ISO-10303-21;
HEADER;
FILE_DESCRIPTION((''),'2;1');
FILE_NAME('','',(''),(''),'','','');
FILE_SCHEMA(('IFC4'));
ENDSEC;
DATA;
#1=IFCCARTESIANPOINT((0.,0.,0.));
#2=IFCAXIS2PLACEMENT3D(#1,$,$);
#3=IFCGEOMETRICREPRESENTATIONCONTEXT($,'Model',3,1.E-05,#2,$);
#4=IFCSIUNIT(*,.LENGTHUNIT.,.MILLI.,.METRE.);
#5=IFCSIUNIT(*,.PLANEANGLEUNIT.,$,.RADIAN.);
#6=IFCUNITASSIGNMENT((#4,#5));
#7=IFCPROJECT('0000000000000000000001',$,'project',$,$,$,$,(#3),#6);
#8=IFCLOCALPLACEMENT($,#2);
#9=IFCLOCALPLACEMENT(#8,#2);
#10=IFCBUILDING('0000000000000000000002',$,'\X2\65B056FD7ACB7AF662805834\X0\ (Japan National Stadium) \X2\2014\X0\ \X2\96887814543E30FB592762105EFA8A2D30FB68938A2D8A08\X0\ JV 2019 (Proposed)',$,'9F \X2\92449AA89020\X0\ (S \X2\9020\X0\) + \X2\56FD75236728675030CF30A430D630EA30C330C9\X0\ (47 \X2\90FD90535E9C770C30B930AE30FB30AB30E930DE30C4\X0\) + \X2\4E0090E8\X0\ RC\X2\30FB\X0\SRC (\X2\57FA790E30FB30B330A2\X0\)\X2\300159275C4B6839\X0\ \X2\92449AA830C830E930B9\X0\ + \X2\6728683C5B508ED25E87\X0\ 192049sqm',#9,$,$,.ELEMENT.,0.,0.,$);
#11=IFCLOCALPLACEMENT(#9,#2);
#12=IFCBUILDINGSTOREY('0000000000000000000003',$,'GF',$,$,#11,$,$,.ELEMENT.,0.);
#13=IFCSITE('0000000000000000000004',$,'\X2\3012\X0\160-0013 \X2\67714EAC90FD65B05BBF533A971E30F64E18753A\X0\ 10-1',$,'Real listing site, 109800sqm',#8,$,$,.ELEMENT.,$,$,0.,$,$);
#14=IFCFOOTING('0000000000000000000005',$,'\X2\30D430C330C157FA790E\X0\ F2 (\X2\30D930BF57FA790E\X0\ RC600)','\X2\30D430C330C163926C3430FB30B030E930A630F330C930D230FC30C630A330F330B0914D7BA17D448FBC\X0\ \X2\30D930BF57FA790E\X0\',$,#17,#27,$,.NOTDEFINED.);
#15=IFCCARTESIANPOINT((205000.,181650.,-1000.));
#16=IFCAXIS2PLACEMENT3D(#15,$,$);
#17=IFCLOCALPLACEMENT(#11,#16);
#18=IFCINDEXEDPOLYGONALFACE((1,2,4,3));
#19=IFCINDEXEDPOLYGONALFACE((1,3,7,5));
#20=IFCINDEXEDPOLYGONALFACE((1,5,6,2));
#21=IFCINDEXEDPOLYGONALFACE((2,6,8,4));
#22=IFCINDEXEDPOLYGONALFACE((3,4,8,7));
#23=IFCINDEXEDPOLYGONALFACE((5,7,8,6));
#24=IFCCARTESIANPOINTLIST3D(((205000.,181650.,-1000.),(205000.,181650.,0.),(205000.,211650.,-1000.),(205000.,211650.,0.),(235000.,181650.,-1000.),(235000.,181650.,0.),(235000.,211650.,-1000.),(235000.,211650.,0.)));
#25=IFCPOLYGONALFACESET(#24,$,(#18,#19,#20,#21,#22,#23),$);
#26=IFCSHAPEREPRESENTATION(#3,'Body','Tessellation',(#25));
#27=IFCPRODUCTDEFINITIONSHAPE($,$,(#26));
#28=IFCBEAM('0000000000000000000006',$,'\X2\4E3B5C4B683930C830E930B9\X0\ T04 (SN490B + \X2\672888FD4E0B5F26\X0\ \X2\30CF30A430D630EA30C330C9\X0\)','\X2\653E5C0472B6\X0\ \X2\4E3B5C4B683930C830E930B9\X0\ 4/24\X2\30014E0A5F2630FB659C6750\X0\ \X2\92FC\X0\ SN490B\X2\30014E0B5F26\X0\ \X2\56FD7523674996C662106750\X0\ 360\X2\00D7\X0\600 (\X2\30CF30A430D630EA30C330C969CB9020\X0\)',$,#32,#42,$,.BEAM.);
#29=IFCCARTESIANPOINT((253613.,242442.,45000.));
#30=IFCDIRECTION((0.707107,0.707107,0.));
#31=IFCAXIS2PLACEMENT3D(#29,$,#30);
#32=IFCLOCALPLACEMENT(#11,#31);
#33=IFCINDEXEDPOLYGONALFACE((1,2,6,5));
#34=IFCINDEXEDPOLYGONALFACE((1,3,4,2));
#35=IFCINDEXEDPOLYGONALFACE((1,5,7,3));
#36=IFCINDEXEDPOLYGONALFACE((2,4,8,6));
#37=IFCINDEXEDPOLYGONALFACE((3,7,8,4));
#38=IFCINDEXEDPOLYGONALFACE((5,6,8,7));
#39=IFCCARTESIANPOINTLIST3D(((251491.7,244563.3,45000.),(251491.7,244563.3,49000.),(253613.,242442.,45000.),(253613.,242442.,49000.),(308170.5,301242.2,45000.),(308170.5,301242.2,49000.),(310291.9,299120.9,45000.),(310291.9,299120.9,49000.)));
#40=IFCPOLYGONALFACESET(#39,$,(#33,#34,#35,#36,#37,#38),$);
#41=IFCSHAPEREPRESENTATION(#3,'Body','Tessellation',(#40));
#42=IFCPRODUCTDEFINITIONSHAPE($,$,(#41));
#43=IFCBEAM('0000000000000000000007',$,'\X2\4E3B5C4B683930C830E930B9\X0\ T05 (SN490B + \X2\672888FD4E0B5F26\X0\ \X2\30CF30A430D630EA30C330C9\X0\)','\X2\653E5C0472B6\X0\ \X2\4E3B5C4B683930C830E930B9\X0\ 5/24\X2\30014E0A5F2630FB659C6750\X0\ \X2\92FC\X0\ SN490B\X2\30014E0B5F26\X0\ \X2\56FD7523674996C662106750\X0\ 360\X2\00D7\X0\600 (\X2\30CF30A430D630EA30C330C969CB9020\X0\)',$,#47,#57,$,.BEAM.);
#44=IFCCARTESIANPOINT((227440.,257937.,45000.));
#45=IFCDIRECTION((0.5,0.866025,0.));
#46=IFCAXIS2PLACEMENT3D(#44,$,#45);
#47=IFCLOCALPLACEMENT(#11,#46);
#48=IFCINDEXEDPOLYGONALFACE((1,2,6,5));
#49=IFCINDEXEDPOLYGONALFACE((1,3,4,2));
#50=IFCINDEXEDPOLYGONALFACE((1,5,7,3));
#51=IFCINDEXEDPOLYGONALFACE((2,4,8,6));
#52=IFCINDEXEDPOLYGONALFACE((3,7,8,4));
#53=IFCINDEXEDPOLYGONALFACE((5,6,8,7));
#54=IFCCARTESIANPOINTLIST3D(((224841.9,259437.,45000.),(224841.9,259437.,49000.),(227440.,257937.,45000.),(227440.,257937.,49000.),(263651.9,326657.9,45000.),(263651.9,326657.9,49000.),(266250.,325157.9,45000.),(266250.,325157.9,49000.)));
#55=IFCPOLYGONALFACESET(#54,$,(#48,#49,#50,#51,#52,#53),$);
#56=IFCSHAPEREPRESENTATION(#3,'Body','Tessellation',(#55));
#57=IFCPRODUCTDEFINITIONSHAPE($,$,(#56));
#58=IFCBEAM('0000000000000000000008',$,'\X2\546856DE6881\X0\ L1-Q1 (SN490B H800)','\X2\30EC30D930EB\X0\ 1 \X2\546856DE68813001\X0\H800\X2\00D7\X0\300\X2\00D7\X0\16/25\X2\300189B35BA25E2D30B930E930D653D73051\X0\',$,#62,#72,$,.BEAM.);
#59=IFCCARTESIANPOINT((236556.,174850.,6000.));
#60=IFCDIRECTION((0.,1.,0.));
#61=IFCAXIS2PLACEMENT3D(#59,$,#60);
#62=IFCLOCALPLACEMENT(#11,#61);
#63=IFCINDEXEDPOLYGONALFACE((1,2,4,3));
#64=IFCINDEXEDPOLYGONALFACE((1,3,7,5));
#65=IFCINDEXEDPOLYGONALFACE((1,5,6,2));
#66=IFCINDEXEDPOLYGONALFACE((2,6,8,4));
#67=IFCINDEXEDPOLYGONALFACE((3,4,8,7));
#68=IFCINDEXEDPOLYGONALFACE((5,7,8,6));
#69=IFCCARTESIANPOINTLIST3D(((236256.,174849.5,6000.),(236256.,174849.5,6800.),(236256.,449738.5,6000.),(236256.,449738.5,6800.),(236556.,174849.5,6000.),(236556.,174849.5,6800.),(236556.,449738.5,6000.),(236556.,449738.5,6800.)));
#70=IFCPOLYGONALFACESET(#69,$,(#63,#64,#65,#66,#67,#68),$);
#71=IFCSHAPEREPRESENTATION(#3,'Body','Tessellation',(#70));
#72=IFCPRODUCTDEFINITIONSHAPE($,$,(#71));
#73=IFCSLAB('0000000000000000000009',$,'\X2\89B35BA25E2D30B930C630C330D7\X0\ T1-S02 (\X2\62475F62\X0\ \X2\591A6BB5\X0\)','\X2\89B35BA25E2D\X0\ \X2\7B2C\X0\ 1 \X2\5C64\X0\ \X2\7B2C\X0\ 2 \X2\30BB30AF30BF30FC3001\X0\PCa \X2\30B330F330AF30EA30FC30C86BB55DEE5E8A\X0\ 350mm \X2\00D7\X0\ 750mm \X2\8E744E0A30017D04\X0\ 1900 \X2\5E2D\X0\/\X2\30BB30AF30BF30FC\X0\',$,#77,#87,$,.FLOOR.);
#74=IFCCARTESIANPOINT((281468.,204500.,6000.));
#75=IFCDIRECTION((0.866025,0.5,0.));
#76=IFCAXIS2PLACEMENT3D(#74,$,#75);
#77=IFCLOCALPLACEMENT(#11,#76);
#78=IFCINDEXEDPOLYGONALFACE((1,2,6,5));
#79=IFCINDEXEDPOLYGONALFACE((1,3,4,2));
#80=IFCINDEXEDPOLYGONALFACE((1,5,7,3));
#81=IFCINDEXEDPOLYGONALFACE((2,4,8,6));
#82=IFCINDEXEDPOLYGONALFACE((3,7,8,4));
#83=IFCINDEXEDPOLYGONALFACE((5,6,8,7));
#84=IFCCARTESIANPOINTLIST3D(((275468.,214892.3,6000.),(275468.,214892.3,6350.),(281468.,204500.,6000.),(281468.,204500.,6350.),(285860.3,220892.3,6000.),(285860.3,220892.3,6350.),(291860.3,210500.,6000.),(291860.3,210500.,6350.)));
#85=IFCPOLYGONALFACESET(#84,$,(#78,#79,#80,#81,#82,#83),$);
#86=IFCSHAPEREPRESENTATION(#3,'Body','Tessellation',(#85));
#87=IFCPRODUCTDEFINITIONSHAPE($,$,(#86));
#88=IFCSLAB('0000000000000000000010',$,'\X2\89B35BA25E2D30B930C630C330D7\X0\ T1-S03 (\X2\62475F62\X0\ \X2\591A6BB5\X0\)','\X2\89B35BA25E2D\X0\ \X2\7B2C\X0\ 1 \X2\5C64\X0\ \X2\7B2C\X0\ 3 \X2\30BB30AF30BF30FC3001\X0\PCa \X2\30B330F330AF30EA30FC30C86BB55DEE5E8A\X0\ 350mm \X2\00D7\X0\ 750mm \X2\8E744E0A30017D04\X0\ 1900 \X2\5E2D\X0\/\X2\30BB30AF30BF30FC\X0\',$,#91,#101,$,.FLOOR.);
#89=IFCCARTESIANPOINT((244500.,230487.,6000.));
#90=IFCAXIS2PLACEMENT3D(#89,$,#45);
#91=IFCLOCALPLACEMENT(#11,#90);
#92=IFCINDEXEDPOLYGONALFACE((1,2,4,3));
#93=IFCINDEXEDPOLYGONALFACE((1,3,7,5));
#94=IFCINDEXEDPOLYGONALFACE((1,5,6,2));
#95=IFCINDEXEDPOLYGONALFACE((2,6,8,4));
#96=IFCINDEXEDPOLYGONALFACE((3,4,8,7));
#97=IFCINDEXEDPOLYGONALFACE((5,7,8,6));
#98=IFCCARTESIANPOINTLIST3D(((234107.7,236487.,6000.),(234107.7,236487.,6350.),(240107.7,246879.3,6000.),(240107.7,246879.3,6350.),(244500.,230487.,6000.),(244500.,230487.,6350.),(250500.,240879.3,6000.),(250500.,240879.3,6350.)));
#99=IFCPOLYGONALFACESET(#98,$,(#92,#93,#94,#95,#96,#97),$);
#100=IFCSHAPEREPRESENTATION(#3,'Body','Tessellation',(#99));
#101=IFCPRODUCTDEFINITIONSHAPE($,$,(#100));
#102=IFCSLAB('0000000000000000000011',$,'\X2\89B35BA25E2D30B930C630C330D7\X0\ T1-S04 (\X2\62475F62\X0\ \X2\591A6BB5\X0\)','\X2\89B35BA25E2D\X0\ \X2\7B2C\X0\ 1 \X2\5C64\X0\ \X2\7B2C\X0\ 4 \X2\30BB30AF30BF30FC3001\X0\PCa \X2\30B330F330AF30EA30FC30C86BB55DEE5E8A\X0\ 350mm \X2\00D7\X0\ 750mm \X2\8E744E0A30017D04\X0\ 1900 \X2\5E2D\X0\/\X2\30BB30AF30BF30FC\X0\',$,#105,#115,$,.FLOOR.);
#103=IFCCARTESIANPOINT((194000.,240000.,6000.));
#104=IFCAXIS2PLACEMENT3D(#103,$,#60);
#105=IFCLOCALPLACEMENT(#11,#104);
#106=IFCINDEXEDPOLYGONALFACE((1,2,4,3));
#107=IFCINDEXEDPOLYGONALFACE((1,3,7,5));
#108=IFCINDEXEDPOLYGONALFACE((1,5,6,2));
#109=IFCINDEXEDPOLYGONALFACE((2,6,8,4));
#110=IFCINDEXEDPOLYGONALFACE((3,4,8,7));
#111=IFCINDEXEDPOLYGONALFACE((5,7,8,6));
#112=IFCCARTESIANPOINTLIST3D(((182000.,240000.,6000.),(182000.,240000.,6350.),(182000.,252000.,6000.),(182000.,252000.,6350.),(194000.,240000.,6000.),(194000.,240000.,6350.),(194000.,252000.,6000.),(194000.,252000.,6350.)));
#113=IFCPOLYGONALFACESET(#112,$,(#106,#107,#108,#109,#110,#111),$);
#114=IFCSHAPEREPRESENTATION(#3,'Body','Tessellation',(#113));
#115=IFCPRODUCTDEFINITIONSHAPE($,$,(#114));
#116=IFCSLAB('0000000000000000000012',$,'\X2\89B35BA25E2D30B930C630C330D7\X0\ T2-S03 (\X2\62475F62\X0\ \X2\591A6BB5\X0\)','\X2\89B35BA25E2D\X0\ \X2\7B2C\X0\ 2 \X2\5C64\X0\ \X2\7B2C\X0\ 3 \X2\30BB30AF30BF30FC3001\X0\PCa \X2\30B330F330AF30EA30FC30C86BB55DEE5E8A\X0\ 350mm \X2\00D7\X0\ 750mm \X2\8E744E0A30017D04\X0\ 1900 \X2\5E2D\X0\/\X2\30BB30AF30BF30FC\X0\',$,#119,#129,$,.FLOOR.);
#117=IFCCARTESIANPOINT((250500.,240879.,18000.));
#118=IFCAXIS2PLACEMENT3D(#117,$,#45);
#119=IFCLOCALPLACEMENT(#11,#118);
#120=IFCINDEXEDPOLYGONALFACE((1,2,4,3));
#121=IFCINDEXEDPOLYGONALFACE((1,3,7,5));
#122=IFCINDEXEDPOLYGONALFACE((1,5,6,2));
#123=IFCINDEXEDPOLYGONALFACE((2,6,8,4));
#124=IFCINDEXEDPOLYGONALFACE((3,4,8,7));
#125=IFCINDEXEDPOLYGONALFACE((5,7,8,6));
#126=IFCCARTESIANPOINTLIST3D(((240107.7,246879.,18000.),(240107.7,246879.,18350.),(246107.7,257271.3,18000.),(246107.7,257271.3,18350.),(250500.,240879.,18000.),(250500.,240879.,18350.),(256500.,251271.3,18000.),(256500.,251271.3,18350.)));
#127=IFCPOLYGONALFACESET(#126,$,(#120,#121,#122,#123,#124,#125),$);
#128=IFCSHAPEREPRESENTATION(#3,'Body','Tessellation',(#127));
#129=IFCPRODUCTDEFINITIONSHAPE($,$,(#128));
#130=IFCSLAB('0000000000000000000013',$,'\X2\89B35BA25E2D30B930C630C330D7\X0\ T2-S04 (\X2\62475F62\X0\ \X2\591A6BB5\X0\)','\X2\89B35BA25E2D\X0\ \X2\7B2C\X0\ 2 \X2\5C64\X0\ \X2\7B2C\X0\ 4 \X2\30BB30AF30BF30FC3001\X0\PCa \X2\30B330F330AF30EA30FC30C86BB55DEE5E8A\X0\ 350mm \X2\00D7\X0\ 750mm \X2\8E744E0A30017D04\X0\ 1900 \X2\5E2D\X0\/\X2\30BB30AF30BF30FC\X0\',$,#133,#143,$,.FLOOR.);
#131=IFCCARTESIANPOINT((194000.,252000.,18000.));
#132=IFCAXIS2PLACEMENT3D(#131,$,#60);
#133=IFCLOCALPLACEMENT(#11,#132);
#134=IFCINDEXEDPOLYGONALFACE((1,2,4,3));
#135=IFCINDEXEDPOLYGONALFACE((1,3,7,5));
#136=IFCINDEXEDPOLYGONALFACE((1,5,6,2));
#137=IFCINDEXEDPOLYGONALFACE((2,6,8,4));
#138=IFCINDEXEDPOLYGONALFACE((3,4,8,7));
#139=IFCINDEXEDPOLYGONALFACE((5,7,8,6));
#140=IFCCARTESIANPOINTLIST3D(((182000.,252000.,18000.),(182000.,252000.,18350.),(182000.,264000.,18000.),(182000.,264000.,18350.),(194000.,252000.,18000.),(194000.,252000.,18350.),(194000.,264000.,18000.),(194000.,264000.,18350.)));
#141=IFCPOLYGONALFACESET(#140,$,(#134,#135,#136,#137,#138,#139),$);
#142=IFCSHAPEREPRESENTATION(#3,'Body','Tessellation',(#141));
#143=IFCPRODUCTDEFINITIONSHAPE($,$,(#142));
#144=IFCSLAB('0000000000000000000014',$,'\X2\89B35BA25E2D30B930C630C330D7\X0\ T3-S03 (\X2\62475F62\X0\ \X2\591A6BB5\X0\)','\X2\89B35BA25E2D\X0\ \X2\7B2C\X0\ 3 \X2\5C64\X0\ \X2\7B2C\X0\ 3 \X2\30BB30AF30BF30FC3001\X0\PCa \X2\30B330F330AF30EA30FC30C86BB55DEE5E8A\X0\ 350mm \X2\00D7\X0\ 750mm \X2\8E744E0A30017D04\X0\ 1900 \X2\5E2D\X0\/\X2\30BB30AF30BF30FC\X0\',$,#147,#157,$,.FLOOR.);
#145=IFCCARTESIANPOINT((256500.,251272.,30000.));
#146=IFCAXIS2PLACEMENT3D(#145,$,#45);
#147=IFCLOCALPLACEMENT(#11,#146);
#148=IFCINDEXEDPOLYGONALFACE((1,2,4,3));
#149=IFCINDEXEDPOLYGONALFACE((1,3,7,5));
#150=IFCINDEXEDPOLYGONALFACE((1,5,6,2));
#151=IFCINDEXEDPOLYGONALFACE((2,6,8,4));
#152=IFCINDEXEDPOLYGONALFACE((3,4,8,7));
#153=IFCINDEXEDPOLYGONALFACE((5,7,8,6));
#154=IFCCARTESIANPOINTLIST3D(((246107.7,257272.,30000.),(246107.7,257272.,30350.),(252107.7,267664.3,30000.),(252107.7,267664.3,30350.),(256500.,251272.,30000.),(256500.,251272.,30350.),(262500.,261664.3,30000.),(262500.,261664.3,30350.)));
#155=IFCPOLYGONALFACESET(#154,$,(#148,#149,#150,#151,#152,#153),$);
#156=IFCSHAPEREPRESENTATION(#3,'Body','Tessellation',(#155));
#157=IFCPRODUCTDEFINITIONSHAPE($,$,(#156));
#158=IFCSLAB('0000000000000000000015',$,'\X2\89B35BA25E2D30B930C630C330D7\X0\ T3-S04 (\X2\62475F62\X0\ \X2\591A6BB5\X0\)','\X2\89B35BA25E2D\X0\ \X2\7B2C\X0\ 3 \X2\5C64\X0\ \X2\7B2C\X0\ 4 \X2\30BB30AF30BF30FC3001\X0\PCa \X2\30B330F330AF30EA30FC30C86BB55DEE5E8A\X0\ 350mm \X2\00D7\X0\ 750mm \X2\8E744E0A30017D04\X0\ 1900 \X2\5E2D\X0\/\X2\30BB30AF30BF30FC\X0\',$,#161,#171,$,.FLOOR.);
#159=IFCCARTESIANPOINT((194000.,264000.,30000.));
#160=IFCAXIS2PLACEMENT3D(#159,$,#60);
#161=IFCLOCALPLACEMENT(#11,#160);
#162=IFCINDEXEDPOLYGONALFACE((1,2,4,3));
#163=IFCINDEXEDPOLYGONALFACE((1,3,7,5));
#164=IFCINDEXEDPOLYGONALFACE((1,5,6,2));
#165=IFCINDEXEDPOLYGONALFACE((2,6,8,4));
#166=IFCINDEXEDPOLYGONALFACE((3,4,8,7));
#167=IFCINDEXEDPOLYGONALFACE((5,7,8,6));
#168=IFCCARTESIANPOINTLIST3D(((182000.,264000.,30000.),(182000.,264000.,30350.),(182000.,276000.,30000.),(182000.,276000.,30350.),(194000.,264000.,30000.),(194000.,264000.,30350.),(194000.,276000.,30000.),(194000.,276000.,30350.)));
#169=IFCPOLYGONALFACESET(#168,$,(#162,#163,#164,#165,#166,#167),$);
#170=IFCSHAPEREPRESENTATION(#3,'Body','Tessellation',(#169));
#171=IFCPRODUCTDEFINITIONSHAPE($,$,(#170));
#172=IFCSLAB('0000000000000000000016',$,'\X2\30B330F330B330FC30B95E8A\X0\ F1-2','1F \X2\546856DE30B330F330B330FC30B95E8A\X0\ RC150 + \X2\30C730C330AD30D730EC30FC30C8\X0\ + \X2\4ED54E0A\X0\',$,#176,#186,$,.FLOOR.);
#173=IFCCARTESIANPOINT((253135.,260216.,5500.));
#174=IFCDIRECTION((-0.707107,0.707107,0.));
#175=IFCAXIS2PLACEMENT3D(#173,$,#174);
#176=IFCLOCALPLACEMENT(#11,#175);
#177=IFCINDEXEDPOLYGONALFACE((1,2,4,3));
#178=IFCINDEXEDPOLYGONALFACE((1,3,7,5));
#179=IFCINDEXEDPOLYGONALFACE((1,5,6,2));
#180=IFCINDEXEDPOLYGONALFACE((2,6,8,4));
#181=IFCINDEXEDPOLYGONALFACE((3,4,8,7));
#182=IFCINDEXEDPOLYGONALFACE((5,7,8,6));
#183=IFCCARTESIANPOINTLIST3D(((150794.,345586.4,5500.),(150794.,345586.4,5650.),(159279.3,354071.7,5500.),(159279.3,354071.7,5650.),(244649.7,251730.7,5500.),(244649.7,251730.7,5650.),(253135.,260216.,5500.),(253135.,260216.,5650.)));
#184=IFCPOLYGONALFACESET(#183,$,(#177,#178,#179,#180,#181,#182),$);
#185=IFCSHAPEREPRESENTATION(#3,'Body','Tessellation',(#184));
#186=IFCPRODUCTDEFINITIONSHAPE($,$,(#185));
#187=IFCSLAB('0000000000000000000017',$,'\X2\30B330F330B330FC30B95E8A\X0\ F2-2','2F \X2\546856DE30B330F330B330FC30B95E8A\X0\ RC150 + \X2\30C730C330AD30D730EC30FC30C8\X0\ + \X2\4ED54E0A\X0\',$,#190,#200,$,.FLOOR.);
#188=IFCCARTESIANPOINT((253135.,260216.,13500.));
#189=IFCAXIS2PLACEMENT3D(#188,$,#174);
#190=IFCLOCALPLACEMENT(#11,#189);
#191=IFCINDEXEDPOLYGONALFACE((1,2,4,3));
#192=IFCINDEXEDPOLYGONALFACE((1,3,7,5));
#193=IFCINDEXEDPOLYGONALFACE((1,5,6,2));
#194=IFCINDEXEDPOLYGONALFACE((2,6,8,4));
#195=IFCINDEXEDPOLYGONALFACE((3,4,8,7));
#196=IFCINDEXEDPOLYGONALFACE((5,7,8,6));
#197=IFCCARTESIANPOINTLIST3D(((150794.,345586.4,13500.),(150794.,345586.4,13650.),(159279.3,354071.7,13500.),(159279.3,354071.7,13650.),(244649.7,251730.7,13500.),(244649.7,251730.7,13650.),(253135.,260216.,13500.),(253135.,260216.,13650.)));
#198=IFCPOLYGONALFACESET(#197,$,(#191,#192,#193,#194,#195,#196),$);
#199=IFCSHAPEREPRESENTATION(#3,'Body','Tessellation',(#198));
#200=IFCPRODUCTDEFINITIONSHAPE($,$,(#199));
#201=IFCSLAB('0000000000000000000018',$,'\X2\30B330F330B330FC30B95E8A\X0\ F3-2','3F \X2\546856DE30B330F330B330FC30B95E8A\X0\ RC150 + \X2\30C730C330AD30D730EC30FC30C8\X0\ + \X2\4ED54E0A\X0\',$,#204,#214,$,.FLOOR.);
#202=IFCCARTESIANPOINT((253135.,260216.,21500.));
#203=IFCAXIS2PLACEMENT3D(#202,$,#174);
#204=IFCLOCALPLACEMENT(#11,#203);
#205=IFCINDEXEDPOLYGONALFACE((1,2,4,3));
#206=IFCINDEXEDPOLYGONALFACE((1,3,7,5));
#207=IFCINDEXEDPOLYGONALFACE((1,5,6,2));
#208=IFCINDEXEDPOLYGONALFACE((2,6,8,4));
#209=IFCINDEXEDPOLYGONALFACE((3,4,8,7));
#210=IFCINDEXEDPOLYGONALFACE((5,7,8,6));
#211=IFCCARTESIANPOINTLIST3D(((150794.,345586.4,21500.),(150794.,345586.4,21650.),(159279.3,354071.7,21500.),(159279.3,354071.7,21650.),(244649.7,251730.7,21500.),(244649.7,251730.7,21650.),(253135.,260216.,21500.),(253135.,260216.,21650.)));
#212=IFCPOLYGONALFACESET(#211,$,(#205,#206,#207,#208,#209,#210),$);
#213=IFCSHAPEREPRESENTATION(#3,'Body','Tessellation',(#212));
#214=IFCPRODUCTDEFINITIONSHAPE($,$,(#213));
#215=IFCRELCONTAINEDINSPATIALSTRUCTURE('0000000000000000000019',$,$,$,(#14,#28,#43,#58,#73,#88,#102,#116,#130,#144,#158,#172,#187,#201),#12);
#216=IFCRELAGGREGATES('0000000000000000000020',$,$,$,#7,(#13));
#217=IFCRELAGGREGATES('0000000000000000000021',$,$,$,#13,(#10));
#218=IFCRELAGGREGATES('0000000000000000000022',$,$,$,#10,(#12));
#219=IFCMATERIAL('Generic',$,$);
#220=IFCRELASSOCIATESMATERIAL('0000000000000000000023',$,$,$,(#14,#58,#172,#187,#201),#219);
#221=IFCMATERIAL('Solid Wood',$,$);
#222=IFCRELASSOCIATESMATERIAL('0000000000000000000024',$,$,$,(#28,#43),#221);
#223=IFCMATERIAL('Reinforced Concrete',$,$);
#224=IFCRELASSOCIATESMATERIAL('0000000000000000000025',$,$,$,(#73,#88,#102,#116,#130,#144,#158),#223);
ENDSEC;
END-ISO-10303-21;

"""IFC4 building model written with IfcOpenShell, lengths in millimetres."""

from ifc_helpers import new_model, si_unit, frame, frame_2d, origin, place, context, project, spatial, rectangle, extrude, material, element, save


model = new_model("IFC4")

# Units and contexts
model_context = context("Model", 3, precision=1e-05, world=origin())
ifc_project = project(units=[si_unit("LENGTHUNIT", "METRE", prefix="MILLI"), si_unit("PLANEANGLEUNIT", "RADIAN")], contexts=[model_context])

# Site, building, storey
site_placement = place(None, origin())
site = spatial("IfcSite", under=ifc_project, at=site_placement, Name="〒160-0013 東京都新宿区霞ヶ丘町 10-1", ObjectType="Real listing site, 109800sqm", CompositionType="ELEMENT", RefElevation=0.0)
building_placement = place(site_placement, origin())
building = spatial("IfcBuilding", under=site, at=building_placement, Name="新国立競技場 (Japan National Stadium) — 隈研吾・大成建設・梓設計 JV 2019 (Proposed)", ObjectType="9F 鉄骨造 (S 造) + 国産木材ハイブリッド (47 都道府県スギ・カラマツ) + 一部 RC・SRC (基礎・コア)、大屋根 鉄骨トラス + 木格子軒庇 192049sqm", CompositionType="ELEMENT", ElevationOfRefHeight=0.0, ElevationOfTerrain=0.0)
storey_placement = place(building_placement, origin())
storey = spatial("IfcBuildingStorey", under=building, at=storey_placement, Name="GF", CompositionType="ELEMENT", Elevation=0.0)

# Footing
ifc_material_1 = material(Name="Generic")
footing_placement = place(storey_placement, frame((205000.0, 181650.0, -1000.0)))
element("IfcFooting", 1, at=footing_placement, inside=storey, material=ifc_material_1, Name="ピッチ基礎 F2 (ベタ基礎 RC600)", Description="ピッチ排水・グラウンドヒーティング配管組込 ベタ基礎", PredefinedType="NOTDEFINED", context=model_context, shape_type="SweptSolid", body=[
    extrude(rectangle(XDim=30000.0, YDim=30000.0, at=frame_2d((15000.0, 15000.0))), frame((205000.0, 181650.0, -1000.0)), (0.0, 0.0, 1.0), 1000.0),
])

# Beams
ifc_material_2 = material(Name="Solid Wood")
beam_1_placement = place(storey_placement, frame((253613.0, 242442.0, 45000.0), x_axis=(0.707107, 0.707107, 0.0)))
element("IfcBeam", 2, at=beam_1_placement, inside=storey, material=ifc_material_2, Name="主屋根トラス T04 (SN490B + 木製下弦 ハイブリッド)", Description="放射状 主屋根トラス 4/24、上弦・斜材 鋼 SN490B、下弦 国産杉集成材 360×600 (ハイブリッド構造)", PredefinedType="BEAM", context=model_context, shape_type="SweptSolid", body=[
    extrude(rectangle(XDim=80156.0, YDim=3000.0, at=frame_2d((40078.0, 1500.0))), frame((253613.0, 242442.0, 45000.0), x_axis=(0.707107, 0.707107, 0.0)), (0.0, 0.0, 1.0), 4000.0),
])
beam_2_placement = place(storey_placement, frame((227440.0, 257937.0, 45000.0), x_axis=(0.5, 0.866025, 0.0)))
element("IfcBeam", 3, at=beam_2_placement, inside=storey, material=ifc_material_2, Name="主屋根トラス T05 (SN490B + 木製下弦 ハイブリッド)", Description="放射状 主屋根トラス 5/24、上弦・斜材 鋼 SN490B、下弦 国産杉集成材 360×600 (ハイブリッド構造)", PredefinedType="BEAM", context=model_context, shape_type="SweptSolid", body=[
    extrude(rectangle(XDim=77620.0, YDim=3000.0, at=frame_2d((38810.0, 1500.0))), frame((227440.0, 257937.0, 45000.0), x_axis=(0.5, 0.866025, 0.0)), (0.0, 0.0, 1.0), 4000.0),
])
beam_3_placement = place(storey_placement, frame((236556.0, 174850.0, 6000.0), x_axis=(0.0, 1.0, 0.0)))
element("IfcBeam", 4, at=beam_3_placement, inside=storey, material=ifc_material_1, Name="周回梁 L1-Q1 (SN490B H800)", Description="レベル 1 周回梁、H800×300×16/25、観客席スラブ受け", PredefinedType="BEAM", context=model_context, shape_type="SweptSolid", body=[
    extrude(rectangle(XDim=274889.0, YDim=300.0, at=frame_2d((137444.0, 150.0))), frame((236556.0, 174850.0, 6000.0), x_axis=(0.0, 1.0, 0.0)), (0.0, 0.0, 1.0), 800.0),
])

# Slabs
ifc_material_3 = material(Name="Reinforced Concrete")
slab_1_placement = place(storey_placement, frame((281468.0, 204500.0, 6000.0), x_axis=(0.866025, 0.5, 0.0)))
element("IfcSlab", 5, at=slab_1_placement, inside=storey, material=ifc_material_3, Name="観客席ステップ T1-S02 (扇形 多段)", Description="観客席 第 1 層 第 2 セクター、PCa コンクリート段差床 350mm × 750mm 蹴上、約 1900 席/セクター", PredefinedType="FLOOR", context=model_context, shape_type="SweptSolid", body=[
    extrude(rectangle(XDim=12000.0, YDim=12000.0, at=frame_2d((6000.0, 6000.0))), frame((281468.0, 204500.0, 6000.0), x_axis=(0.866025, 0.5, 0.0)), (0.0, 0.0, 1.0), 350.0),
])
slab_2_placement = place(storey_placement, frame((244500.0, 230487.0, 6000.0), x_axis=(0.5, 0.866025, 0.0)))
element("IfcSlab", 6, at=slab_2_placement, inside=storey, material=ifc_material_3, Name="観客席ステップ T1-S03 (扇形 多段)", Description="観客席 第 1 層 第 3 セクター、PCa コンクリート段差床 350mm × 750mm 蹴上、約 1900 席/セクター", PredefinedType="FLOOR", context=model_context, shape_type="SweptSolid", body=[
    extrude(rectangle(XDim=12000.0, YDim=12000.0, at=frame_2d((6000.0, 6000.0))), frame((244500.0, 230487.0, 6000.0), x_axis=(0.5, 0.866025, 0.0)), (0.0, 0.0, 1.0), 350.0),
])
slab_3_placement = place(storey_placement, frame((194000.0, 240000.0, 6000.0), x_axis=(0.0, 1.0, 0.0)))
element("IfcSlab", 7, at=slab_3_placement, inside=storey, material=ifc_material_3, Name="観客席ステップ T1-S04 (扇形 多段)", Description="観客席 第 1 層 第 4 セクター、PCa コンクリート段差床 350mm × 750mm 蹴上、約 1900 席/セクター", PredefinedType="FLOOR", context=model_context, shape_type="SweptSolid", body=[
    extrude(rectangle(XDim=12000.0, YDim=12000.0, at=frame_2d((6000.0, 6000.0))), frame((194000.0, 240000.0, 6000.0), x_axis=(0.0, 1.0, 0.0)), (0.0, 0.0, 1.0), 350.0),
])
slab_4_placement = place(storey_placement, frame((250500.0, 240879.0, 18000.0), x_axis=(0.5, 0.866025, 0.0)))
element("IfcSlab", 8, at=slab_4_placement, inside=storey, material=ifc_material_3, Name="観客席ステップ T2-S03 (扇形 多段)", Description="観客席 第 2 層 第 3 セクター、PCa コンクリート段差床 350mm × 750mm 蹴上、約 1900 席/セクター", PredefinedType="FLOOR", context=model_context, shape_type="SweptSolid", body=[
    extrude(rectangle(XDim=12000.0, YDim=12000.0, at=frame_2d((6000.0, 6000.0))), frame((250500.0, 240879.0, 18000.0), x_axis=(0.5, 0.866025, 0.0)), (0.0, 0.0, 1.0), 350.0),
])
slab_5_placement = place(storey_placement, frame((194000.0, 252000.0, 18000.0), x_axis=(0.0, 1.0, 0.0)))
element("IfcSlab", 9, at=slab_5_placement, inside=storey, material=ifc_material_3, Name="観客席ステップ T2-S04 (扇形 多段)", Description="観客席 第 2 層 第 4 セクター、PCa コンクリート段差床 350mm × 750mm 蹴上、約 1900 席/セクター", PredefinedType="FLOOR", context=model_context, shape_type="SweptSolid", body=[
    extrude(rectangle(XDim=12000.0, YDim=12000.0, at=frame_2d((6000.0, 6000.0))), frame((194000.0, 252000.0, 18000.0), x_axis=(0.0, 1.0, 0.0)), (0.0, 0.0, 1.0), 350.0),
])
slab_6_placement = place(storey_placement, frame((256500.0, 251272.0, 30000.0), x_axis=(0.5, 0.866025, 0.0)))
element("IfcSlab", 10, at=slab_6_placement, inside=storey, material=ifc_material_3, Name="観客席ステップ T3-S03 (扇形 多段)", Description="観客席 第 3 層 第 3 セクター、PCa コンクリート段差床 350mm × 750mm 蹴上、約 1900 席/セクター", PredefinedType="FLOOR", context=model_context, shape_type="SweptSolid", body=[
    extrude(rectangle(XDim=12000.0, YDim=12000.0, at=frame_2d((6000.0, 6000.0))), frame((256500.0, 251272.0, 30000.0), x_axis=(0.5, 0.866025, 0.0)), (0.0, 0.0, 1.0), 350.0),
])
slab_7_placement = place(storey_placement, frame((194000.0, 264000.0, 30000.0), x_axis=(0.0, 1.0, 0.0)))
element("IfcSlab", 11, at=slab_7_placement, inside=storey, material=ifc_material_3, Name="観客席ステップ T3-S04 (扇形 多段)", Description="観客席 第 3 層 第 4 セクター、PCa コンクリート段差床 350mm × 750mm 蹴上、約 1900 席/セクター", PredefinedType="FLOOR", context=model_context, shape_type="SweptSolid", body=[
    extrude(rectangle(XDim=12000.0, YDim=12000.0, at=frame_2d((6000.0, 6000.0))), frame((194000.0, 264000.0, 30000.0), x_axis=(0.0, 1.0, 0.0)), (0.0, 0.0, 1.0), 350.0),
])
slab_8_placement = place(storey_placement, frame((253135.0, 260216.0, 5500.0), x_axis=(-0.707107, 0.707107, 0.0)))
element("IfcSlab", 12, at=slab_8_placement, inside=storey, material=ifc_material_1, Name="コンコース床 F1-2", Description="1F 周回コンコース床 RC150 + デッキプレート + 仕上", PredefinedType="FLOOR", context=model_context, shape_type="SweptSolid", body=[
    extrude(rectangle(XDim=132732.0, YDim=12000.0, at=frame_2d((66366.0, 6000.0))), frame((253135.0, 260216.0, 5500.0), x_axis=(-0.707107, 0.707107, 0.0)), (0.0, 0.0, 1.0), 150.0),
])
slab_9_placement = place(storey_placement, frame((253135.0, 260216.0, 13500.0), x_axis=(-0.707107, 0.707107, 0.0)))
element("IfcSlab", 13, at=slab_9_placement, inside=storey, material=ifc_material_1, Name="コンコース床 F2-2", Description="2F 周回コンコース床 RC150 + デッキプレート + 仕上", PredefinedType="FLOOR", context=model_context, shape_type="SweptSolid", body=[
    extrude(rectangle(XDim=132732.0, YDim=12000.0, at=frame_2d((66366.0, 6000.0))), frame((253135.0, 260216.0, 13500.0), x_axis=(-0.707107, 0.707107, 0.0)), (0.0, 0.0, 1.0), 150.0),
])
slab_10_placement = place(storey_placement, frame((253135.0, 260216.0, 21500.0), x_axis=(-0.707107, 0.707107, 0.0)))
element("IfcSlab", 14, at=slab_10_placement, inside=storey, material=ifc_material_1, Name="コンコース床 F3-2", Description="3F 周回コンコース床 RC150 + デッキプレート + 仕上", PredefinedType="FLOOR", context=model_context, shape_type="SweptSolid", body=[
    extrude(rectangle(XDim=132732.0, YDim=12000.0, at=frame_2d((66366.0, 6000.0))), frame((253135.0, 260216.0, 21500.0), x_axis=(-0.707107, 0.707107, 0.0)), (0.0, 0.0, 1.0), 150.0),
])

save(model, "model.ifc")
